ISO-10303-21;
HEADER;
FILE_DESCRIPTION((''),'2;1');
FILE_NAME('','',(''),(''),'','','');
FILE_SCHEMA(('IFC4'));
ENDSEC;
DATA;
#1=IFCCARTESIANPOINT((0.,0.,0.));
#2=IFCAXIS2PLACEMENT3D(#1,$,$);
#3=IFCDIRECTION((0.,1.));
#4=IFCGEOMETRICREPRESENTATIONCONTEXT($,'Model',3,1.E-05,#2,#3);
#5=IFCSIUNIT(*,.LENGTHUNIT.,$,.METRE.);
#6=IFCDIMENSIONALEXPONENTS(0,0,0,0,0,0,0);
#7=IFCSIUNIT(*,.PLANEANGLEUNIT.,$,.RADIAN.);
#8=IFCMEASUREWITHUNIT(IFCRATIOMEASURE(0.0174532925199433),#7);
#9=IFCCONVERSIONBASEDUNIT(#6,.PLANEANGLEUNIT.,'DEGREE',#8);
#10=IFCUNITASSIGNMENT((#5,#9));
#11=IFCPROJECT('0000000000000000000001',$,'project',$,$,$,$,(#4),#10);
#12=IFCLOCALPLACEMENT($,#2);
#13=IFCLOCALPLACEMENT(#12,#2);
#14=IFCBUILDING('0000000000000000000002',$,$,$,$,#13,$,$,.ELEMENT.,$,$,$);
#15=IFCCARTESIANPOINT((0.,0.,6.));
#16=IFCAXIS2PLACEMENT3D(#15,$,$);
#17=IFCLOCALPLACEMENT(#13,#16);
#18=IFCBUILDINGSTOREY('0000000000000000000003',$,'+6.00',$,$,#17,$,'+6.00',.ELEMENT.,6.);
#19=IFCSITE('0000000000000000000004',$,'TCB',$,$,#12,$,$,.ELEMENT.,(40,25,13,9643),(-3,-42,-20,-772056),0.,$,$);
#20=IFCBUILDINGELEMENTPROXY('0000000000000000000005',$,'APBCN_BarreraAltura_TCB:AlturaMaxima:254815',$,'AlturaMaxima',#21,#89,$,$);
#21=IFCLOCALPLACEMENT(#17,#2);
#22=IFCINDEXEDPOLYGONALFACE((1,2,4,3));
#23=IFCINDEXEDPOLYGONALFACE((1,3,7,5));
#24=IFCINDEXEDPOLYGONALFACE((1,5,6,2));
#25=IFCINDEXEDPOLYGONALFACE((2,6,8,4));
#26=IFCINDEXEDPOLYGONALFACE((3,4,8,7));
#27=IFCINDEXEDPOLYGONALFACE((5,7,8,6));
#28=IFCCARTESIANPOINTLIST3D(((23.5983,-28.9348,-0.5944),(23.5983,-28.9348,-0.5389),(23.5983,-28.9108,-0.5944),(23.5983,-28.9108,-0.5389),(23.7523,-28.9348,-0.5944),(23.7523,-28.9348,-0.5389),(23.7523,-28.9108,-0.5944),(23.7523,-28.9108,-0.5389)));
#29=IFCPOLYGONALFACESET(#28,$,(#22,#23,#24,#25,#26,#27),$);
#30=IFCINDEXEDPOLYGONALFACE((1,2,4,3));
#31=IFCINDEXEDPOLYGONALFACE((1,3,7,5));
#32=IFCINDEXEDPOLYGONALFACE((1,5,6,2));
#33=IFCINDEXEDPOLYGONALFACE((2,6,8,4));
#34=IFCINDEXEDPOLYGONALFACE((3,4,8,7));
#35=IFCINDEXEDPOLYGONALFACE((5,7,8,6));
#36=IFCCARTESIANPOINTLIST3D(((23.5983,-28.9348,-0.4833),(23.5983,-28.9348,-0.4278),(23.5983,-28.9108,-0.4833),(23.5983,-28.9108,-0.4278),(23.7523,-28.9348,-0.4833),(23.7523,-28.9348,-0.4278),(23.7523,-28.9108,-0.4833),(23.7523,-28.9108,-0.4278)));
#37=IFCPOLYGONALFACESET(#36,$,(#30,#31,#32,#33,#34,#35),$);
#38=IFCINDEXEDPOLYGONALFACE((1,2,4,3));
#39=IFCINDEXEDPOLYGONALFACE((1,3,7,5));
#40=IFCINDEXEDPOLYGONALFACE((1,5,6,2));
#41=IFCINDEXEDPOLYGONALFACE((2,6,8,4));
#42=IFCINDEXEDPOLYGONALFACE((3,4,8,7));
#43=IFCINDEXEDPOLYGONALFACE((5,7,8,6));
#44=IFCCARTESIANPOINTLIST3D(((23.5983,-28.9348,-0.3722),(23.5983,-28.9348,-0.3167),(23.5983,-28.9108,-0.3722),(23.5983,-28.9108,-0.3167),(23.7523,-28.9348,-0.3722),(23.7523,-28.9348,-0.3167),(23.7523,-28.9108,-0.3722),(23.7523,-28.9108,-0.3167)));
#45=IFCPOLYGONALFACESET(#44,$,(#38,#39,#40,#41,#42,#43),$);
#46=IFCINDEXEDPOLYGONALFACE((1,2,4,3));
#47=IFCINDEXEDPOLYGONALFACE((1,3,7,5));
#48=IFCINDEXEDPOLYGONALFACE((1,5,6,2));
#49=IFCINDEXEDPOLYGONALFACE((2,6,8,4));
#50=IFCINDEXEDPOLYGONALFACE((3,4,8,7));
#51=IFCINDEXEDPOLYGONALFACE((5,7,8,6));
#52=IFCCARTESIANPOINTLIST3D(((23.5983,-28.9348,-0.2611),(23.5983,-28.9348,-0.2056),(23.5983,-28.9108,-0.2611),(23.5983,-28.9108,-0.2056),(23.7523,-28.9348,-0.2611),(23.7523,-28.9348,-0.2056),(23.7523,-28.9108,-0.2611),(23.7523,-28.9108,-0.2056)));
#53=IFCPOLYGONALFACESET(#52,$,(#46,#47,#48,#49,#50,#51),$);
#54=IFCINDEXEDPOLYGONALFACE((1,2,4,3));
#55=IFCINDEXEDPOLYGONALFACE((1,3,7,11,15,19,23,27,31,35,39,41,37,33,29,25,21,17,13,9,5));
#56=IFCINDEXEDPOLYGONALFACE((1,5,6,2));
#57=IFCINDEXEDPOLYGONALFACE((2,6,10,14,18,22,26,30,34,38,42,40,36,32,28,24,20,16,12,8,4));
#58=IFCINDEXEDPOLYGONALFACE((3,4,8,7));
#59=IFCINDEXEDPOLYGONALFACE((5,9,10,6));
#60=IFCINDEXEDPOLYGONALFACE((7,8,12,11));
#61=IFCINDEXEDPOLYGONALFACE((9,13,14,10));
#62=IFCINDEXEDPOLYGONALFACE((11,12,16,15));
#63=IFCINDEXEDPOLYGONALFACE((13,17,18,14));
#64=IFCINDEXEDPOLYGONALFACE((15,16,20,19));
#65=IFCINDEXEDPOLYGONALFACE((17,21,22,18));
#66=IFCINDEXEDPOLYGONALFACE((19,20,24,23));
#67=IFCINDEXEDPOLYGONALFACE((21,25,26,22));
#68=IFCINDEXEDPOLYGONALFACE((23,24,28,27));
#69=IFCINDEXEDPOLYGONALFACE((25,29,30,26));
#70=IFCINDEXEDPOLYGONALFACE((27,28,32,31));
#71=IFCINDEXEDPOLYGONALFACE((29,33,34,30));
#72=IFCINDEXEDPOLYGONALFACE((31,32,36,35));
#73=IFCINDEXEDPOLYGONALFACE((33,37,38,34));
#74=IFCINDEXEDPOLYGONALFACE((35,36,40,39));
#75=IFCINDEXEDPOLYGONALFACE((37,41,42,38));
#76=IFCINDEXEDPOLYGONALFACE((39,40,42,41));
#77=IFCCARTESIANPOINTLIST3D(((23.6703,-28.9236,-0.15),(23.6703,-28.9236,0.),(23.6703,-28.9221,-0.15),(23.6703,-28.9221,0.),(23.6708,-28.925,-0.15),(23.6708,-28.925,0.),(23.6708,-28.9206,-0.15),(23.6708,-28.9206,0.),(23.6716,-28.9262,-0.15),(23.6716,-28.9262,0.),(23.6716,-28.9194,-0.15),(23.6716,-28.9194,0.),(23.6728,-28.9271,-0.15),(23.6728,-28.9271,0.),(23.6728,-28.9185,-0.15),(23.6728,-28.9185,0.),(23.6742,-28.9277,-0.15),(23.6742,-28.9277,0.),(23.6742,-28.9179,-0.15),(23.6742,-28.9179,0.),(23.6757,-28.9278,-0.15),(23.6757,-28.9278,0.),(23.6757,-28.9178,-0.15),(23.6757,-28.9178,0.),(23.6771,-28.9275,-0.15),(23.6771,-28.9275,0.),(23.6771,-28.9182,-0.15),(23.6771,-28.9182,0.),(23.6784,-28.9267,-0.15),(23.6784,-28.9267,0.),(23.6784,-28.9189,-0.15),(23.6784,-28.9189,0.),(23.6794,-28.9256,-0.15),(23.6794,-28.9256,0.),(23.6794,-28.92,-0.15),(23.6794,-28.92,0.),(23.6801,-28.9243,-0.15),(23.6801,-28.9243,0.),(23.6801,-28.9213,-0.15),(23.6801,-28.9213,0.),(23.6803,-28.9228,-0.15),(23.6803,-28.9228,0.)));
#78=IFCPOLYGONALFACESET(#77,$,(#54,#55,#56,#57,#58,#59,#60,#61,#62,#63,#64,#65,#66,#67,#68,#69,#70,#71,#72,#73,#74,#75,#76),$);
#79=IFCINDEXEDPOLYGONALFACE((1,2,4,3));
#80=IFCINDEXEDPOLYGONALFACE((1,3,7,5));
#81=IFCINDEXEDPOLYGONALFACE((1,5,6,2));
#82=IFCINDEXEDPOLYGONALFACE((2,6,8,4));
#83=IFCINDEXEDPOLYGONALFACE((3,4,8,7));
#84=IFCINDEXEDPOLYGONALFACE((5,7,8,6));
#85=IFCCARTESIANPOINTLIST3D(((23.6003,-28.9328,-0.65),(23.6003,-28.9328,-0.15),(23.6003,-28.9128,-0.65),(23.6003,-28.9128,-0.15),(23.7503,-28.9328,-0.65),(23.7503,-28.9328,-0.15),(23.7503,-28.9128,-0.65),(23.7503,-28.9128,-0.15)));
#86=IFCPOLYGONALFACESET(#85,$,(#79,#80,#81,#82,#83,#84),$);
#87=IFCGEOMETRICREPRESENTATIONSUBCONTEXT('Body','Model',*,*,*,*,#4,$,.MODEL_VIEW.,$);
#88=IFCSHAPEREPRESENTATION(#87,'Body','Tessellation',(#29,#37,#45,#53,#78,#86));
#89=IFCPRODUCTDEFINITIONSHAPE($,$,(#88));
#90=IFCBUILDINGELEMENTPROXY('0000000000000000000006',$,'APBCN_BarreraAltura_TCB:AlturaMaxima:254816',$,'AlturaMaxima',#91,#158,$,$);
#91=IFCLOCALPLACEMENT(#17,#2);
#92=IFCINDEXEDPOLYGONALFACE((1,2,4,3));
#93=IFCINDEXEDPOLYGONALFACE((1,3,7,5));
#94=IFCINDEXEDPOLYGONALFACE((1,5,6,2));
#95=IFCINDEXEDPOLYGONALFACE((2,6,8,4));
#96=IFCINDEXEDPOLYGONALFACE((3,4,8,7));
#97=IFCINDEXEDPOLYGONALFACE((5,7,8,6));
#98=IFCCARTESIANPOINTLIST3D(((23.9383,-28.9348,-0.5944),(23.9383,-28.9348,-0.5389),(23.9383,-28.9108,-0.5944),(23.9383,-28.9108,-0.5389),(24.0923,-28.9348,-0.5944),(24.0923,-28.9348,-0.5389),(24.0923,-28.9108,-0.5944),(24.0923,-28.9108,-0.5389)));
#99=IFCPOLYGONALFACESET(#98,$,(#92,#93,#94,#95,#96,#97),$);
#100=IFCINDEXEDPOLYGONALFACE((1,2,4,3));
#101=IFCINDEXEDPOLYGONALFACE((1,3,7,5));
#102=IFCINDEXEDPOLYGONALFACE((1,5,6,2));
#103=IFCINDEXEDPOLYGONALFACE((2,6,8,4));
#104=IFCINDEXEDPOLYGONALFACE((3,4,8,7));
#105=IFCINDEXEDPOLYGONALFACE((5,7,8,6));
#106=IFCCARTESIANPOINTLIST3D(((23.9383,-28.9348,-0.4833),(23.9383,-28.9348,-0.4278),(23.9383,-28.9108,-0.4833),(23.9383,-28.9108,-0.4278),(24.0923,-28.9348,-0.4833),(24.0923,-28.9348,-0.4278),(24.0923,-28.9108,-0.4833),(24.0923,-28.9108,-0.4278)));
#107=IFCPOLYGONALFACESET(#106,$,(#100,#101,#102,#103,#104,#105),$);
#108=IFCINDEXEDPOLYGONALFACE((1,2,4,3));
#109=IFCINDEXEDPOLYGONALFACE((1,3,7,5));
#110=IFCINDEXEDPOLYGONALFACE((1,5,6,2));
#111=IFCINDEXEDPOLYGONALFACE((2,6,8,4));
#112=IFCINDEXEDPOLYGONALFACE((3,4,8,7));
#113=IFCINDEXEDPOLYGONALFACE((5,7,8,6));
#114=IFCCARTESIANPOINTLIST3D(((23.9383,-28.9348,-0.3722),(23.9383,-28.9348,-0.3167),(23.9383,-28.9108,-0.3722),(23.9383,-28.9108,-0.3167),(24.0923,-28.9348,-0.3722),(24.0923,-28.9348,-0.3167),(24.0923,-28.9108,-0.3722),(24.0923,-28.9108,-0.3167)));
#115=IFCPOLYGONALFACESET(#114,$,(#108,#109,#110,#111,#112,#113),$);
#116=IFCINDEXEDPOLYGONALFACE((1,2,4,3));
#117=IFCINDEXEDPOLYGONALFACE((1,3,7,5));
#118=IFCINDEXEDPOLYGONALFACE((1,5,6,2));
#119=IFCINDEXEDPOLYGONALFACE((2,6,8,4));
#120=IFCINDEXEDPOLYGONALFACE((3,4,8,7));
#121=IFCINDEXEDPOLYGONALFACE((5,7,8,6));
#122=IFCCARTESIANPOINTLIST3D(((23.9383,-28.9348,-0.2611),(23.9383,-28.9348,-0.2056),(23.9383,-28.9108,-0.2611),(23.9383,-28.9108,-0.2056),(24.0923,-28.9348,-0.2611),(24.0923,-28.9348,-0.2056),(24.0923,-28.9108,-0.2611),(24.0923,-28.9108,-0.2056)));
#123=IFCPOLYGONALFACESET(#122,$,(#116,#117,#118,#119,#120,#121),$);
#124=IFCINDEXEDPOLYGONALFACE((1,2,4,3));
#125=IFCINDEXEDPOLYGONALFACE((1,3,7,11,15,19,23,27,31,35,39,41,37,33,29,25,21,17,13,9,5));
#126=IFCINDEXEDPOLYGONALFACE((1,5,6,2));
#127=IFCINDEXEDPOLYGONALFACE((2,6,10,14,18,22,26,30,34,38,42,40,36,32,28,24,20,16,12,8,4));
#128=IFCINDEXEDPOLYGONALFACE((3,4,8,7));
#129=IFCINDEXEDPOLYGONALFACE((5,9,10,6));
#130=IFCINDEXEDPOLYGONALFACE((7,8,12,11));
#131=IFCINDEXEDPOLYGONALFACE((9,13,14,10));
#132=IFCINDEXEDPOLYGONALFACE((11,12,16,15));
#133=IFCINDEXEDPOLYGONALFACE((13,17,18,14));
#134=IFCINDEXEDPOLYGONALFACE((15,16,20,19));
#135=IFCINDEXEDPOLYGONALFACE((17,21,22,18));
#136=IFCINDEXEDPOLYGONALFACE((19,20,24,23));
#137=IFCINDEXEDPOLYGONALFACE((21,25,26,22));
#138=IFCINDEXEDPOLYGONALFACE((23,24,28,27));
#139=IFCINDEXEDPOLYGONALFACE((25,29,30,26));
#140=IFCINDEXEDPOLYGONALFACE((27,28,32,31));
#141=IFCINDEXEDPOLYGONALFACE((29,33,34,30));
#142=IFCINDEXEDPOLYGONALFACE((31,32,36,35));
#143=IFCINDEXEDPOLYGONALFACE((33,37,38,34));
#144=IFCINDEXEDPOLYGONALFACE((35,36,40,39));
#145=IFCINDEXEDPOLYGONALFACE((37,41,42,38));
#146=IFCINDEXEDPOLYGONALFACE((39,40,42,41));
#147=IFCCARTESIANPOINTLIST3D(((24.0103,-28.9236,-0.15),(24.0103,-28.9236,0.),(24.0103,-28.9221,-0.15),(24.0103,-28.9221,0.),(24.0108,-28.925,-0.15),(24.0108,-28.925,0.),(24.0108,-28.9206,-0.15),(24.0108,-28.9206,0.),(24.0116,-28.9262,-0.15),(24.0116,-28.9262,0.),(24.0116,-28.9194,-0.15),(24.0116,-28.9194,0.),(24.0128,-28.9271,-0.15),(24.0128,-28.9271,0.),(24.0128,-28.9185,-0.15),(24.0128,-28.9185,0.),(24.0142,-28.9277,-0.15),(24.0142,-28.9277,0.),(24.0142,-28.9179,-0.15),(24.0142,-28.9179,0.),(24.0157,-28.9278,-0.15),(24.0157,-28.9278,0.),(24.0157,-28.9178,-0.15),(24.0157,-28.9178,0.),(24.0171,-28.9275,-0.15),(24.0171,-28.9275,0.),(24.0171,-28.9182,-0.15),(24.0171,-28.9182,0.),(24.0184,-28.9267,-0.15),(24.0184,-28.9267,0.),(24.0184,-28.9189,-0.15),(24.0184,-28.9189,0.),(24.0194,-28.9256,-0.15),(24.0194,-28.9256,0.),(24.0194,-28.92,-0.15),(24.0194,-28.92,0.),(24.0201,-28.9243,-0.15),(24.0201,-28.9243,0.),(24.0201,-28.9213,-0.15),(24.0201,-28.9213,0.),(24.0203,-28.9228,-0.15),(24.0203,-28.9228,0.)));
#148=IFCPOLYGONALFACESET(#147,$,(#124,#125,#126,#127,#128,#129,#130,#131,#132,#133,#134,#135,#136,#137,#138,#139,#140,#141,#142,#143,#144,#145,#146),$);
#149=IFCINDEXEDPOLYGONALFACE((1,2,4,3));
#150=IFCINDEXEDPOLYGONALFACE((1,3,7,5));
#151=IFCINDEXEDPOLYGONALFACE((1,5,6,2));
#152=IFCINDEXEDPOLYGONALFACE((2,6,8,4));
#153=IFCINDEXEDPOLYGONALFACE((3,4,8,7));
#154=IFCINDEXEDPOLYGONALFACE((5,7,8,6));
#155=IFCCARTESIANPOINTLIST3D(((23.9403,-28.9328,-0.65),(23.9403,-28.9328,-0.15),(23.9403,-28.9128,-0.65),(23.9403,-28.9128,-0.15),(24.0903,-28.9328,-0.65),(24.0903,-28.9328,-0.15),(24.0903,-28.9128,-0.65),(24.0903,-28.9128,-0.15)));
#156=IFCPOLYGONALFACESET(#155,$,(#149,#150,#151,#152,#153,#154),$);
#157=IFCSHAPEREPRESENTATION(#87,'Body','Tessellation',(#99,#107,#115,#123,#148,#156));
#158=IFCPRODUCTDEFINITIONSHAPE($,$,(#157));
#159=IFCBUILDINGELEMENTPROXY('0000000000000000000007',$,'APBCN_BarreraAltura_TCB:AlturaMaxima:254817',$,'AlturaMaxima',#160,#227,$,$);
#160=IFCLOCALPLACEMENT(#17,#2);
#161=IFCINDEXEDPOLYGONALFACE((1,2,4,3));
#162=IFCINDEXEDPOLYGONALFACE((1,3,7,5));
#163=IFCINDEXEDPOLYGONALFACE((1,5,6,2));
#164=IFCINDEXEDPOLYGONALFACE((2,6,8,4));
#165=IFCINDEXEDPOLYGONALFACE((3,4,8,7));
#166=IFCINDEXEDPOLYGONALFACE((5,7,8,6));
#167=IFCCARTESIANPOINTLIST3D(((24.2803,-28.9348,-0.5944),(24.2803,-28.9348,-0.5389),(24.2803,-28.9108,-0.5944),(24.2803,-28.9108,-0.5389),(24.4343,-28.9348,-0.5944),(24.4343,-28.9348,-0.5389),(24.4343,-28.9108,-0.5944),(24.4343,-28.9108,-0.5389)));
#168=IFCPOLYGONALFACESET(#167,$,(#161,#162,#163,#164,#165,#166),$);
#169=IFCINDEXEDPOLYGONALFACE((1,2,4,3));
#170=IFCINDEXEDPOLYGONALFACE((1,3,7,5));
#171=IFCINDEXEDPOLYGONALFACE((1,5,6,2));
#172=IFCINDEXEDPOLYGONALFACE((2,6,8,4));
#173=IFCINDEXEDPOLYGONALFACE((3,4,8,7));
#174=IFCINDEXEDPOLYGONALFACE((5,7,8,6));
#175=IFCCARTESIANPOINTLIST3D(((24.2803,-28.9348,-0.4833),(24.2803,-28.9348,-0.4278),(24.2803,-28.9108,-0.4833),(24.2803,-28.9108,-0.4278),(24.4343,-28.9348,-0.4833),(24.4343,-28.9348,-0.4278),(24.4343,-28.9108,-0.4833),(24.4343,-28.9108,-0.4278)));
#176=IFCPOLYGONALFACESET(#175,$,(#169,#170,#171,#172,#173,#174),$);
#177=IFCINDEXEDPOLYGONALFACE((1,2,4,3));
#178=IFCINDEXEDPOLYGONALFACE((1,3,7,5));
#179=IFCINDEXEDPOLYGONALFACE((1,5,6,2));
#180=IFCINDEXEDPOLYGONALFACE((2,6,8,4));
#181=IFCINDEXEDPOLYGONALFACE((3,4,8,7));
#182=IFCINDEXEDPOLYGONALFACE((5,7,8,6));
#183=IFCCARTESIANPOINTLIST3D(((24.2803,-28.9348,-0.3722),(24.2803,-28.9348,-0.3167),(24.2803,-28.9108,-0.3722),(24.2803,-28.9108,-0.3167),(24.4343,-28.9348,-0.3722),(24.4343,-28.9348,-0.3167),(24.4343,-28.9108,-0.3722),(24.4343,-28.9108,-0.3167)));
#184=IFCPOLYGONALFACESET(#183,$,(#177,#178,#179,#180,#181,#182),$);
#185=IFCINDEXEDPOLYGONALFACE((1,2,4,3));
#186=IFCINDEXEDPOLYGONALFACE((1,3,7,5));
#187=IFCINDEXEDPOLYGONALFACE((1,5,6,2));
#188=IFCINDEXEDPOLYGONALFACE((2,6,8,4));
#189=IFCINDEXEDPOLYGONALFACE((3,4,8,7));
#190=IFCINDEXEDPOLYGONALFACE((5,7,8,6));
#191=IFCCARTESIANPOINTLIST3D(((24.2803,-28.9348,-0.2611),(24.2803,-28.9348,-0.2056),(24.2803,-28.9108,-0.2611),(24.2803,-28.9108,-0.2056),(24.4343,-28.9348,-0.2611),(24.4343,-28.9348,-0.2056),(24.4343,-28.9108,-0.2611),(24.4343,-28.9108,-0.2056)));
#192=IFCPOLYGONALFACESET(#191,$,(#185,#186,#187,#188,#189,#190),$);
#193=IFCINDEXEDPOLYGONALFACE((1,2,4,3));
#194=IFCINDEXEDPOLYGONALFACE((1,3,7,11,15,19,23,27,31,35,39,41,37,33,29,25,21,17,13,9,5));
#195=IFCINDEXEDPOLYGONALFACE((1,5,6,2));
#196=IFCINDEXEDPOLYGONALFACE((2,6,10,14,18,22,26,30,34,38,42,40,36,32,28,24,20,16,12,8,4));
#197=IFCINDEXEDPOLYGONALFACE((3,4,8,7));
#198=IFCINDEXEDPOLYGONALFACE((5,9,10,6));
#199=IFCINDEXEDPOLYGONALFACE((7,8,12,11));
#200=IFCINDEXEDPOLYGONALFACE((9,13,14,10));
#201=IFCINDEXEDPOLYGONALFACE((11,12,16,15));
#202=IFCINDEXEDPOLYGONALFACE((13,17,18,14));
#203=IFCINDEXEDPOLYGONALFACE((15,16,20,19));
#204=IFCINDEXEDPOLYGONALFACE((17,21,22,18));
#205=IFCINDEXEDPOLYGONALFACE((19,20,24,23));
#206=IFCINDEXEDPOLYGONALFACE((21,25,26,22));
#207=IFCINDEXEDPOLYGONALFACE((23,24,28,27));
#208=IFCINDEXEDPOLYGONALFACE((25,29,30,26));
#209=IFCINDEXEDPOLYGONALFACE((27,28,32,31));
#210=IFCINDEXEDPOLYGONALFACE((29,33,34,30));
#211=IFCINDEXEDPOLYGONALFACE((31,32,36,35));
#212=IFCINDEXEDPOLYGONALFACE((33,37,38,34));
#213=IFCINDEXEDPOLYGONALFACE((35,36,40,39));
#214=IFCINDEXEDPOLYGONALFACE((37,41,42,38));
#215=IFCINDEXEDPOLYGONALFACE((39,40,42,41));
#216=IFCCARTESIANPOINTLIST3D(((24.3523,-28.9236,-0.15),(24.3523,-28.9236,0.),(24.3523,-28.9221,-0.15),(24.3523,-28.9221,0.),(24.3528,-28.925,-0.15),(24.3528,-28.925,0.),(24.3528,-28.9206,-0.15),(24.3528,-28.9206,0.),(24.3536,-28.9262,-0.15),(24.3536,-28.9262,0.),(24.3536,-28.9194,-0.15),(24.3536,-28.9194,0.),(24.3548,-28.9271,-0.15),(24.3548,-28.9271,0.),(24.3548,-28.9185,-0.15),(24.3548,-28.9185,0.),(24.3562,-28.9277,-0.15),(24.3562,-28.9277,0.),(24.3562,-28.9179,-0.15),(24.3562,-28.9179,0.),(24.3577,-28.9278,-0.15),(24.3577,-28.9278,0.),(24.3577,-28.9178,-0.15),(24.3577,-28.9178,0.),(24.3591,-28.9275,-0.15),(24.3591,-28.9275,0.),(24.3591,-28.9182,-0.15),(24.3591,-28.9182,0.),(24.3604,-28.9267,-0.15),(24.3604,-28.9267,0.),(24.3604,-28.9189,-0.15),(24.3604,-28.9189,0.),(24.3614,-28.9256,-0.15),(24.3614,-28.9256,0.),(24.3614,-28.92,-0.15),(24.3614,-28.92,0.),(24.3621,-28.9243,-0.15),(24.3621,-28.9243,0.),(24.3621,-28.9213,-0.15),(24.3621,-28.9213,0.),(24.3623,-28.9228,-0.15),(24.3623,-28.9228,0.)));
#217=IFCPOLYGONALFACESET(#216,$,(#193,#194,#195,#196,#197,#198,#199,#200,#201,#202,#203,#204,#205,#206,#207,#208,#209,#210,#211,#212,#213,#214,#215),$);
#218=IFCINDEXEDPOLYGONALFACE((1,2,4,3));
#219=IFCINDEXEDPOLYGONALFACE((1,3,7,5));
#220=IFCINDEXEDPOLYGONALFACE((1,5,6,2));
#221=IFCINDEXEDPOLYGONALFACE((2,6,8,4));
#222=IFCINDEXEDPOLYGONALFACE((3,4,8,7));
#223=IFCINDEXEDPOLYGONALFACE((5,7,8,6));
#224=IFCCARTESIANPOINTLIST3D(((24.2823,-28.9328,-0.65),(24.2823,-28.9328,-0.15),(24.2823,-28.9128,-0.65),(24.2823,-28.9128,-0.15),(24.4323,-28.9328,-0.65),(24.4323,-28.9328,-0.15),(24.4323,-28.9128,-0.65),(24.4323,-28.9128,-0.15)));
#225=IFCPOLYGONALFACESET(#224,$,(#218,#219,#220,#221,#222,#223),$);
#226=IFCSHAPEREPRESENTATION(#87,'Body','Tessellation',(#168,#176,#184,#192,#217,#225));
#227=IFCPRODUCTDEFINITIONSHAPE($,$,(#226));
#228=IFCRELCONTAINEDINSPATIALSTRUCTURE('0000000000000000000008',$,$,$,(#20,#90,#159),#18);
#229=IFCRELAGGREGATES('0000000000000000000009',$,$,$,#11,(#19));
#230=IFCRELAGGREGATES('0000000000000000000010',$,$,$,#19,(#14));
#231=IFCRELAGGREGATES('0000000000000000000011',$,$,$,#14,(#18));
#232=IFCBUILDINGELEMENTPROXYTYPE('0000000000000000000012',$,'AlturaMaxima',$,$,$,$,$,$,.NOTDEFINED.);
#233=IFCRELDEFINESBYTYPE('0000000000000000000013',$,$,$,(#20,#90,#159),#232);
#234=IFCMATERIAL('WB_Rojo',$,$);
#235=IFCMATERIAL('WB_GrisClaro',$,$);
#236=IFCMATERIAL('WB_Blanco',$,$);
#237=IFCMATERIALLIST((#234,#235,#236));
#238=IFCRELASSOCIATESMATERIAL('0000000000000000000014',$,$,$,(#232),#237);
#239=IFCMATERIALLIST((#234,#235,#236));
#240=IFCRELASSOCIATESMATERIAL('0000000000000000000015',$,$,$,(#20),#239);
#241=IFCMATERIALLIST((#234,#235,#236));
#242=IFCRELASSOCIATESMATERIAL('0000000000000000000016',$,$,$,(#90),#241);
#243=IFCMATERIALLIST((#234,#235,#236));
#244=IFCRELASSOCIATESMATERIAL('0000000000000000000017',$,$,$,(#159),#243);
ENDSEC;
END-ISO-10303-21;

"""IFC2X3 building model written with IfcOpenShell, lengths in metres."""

from ifc_helpers import new_model, entity, si_unit, converted_unit, direction, frame, frame_2d, origin, origin_2d_with_axis, place, context, subcontext, project, spatial, rectangle, circle, extrude, source, transform, mapped, material, material_list, type_object, type_shapes, element, save


model = new_model("IFC2X3")

# Units and contexts
model_context = context("Model", 3, precision=1e-05, world=origin(), true_north=direction((0.0, 1.0)))
body_context = subcontext(model_context, "Body", "Model", "MODEL_VIEW")
ifc_project = project(units=[si_unit("LENGTHUNIT", "METRE"), converted_unit("PLANEANGLEUNIT", "DEGREE", entity("IfcRatioMeasure", 0.0174532925199433), si_unit("PLANEANGLEUNIT", "RADIAN"), dimensions=[0, 0, 0, 0, 0, 0, 0])], contexts=[model_context])

# Site, building, storey
site_placement = place(None, origin())
site = spatial("IfcSite", under=ifc_project, at=site_placement, Name="TCB", CompositionType="ELEMENT", RefLatitude=(40, 25, 13, 9643), RefLongitude=(-3, -42, -20, -772056), RefElevation=0.0)
building_placement = place(site_placement, origin())
building = spatial("IfcBuilding", under=site, at=building_placement, CompositionType="ELEMENT")
storey_placement = place(building_placement, frame((0.0, 0.0, 6.0)))
storey = spatial("IfcBuildingStorey", under=building, at=storey_placement, Name="+6.00", LongName="+6.00", CompositionType="ELEMENT", Elevation=6.0)

# Building element proxies
ifc_material_1 = material(Name="WB_Rojo")
ifc_material_2 = material(Name="WB_GrisClaro")
ifc_material_3 = material(Name="WB_Blanco")
ifc_material_list_1 = material_list([ifc_material_1, ifc_material_2, ifc_material_3])
building_element_proxy_type = type_object("IfcBuildingElementProxyType", Name="AlturaMaxima", PredefinedType="NOTDEFINED", material=ifc_material_list_1)
shared_shape = source(origin(), body_context, "Body", "SweptSolid", [
    extrude(rectangle(XDim=0.154, YDim=0.024, at=frame_2d((0.0, 0.0), x_axis=(1.0, 0.0))), frame((0.0, 0.0, -0.5944), z_axis=(0.0, 0.0, 1.0), x_axis=(-1.0, 0.0, 0.0)), (0.0, 0.0, 1.0), 0.0556),
    extrude(rectangle(XDim=0.154, YDim=0.024, at=frame_2d((0.0, 0.0), x_axis=(1.0, 0.0))), frame((0.0, 0.0, -0.4833), z_axis=(0.0, 0.0, 1.0), x_axis=(-1.0, 0.0, 0.0)), (0.0, 0.0, 1.0), 0.0556),
    extrude(rectangle(XDim=0.154, YDim=0.024, at=frame_2d((0.0, 0.0), x_axis=(1.0, 0.0))), frame((0.0, 0.0, -0.3722), z_axis=(0.0, 0.0, 1.0), x_axis=(-1.0, 0.0, 0.0)), (0.0, 0.0, 1.0), 0.0556),
    extrude(rectangle(XDim=0.154, YDim=0.024, at=frame_2d((0.0, 0.0), x_axis=(1.0, 0.0))), frame((0.0, 0.0, -0.2611), z_axis=(0.0, 0.0, 1.0), x_axis=(-1.0, 0.0, 0.0)), (0.0, 0.0, 1.0), 0.0556),
    extrude(circle(Radius=0.005, at=frame_2d((0.0, 0.0), x_axis=(1.0, 0.0))), frame((0.0, 0.0, -0.15)), (0.0, 0.0, 1.0), 0.15),
    extrude(rectangle(XDim=0.02, YDim=0.15, at=origin_2d_with_axis()), frame((0.0, 0.0, -0.65), z_axis=(0.0, 0.0, 1.0), x_axis=(0.0, 1.0, 0.0)), (0.0, 0.0, 1.0), 0.5),
])
type_shapes(building_element_proxy_type, [shared_shape])
ifc_material_list_2 = material_list([ifc_material_1, ifc_material_2, ifc_material_3])
proxy_1_placement = place(storey_placement, frame((23.6753, -28.9228, 0.0)))
element("IfcBuildingElementProxy", 1, at=proxy_1_placement, inside=storey, type_object=building_element_proxy_type, material=ifc_material_list_2, Name="APBCN_BarreraAltura_TCB:AlturaMaxima:254815", ObjectType="AlturaMaxima", context=body_context, shape_type="MappedRepresentation", body=[
    mapped(shared_shape, transform((0.0, 0.0, 0.0), scale=1.0)),
])
ifc_material_list_3 = material_list([ifc_material_1, ifc_material_2, ifc_material_3])
proxy_2_placement = place(storey_placement, frame((24.0153, -28.9228, 0.0)))
element("IfcBuildingElementProxy", 2, at=proxy_2_placement, inside=storey, type_object=building_element_proxy_type, material=ifc_material_list_3, Name="APBCN_BarreraAltura_TCB:AlturaMaxima:254816", ObjectType="AlturaMaxima", context=body_context, shape_type="MappedRepresentation", body=[
    mapped(shared_shape, transform((0.0, 0.0, 0.0), scale=1.0)),
])
ifc_material_list_4 = material_list([ifc_material_1, ifc_material_2, ifc_material_3])
proxy_3_placement = place(storey_placement, frame((24.3573, -28.9228, 0.0)))
element("IfcBuildingElementProxy", 3, at=proxy_3_placement, inside=storey, type_object=building_element_proxy_type, material=ifc_material_list_4, Name="APBCN_BarreraAltura_TCB:AlturaMaxima:254817", ObjectType="AlturaMaxima", context=body_context, shape_type="MappedRepresentation", body=[
    mapped(shared_shape, transform((0.0, 0.0, 0.0), scale=1.0)),
])

save(model, "model.ifc")
